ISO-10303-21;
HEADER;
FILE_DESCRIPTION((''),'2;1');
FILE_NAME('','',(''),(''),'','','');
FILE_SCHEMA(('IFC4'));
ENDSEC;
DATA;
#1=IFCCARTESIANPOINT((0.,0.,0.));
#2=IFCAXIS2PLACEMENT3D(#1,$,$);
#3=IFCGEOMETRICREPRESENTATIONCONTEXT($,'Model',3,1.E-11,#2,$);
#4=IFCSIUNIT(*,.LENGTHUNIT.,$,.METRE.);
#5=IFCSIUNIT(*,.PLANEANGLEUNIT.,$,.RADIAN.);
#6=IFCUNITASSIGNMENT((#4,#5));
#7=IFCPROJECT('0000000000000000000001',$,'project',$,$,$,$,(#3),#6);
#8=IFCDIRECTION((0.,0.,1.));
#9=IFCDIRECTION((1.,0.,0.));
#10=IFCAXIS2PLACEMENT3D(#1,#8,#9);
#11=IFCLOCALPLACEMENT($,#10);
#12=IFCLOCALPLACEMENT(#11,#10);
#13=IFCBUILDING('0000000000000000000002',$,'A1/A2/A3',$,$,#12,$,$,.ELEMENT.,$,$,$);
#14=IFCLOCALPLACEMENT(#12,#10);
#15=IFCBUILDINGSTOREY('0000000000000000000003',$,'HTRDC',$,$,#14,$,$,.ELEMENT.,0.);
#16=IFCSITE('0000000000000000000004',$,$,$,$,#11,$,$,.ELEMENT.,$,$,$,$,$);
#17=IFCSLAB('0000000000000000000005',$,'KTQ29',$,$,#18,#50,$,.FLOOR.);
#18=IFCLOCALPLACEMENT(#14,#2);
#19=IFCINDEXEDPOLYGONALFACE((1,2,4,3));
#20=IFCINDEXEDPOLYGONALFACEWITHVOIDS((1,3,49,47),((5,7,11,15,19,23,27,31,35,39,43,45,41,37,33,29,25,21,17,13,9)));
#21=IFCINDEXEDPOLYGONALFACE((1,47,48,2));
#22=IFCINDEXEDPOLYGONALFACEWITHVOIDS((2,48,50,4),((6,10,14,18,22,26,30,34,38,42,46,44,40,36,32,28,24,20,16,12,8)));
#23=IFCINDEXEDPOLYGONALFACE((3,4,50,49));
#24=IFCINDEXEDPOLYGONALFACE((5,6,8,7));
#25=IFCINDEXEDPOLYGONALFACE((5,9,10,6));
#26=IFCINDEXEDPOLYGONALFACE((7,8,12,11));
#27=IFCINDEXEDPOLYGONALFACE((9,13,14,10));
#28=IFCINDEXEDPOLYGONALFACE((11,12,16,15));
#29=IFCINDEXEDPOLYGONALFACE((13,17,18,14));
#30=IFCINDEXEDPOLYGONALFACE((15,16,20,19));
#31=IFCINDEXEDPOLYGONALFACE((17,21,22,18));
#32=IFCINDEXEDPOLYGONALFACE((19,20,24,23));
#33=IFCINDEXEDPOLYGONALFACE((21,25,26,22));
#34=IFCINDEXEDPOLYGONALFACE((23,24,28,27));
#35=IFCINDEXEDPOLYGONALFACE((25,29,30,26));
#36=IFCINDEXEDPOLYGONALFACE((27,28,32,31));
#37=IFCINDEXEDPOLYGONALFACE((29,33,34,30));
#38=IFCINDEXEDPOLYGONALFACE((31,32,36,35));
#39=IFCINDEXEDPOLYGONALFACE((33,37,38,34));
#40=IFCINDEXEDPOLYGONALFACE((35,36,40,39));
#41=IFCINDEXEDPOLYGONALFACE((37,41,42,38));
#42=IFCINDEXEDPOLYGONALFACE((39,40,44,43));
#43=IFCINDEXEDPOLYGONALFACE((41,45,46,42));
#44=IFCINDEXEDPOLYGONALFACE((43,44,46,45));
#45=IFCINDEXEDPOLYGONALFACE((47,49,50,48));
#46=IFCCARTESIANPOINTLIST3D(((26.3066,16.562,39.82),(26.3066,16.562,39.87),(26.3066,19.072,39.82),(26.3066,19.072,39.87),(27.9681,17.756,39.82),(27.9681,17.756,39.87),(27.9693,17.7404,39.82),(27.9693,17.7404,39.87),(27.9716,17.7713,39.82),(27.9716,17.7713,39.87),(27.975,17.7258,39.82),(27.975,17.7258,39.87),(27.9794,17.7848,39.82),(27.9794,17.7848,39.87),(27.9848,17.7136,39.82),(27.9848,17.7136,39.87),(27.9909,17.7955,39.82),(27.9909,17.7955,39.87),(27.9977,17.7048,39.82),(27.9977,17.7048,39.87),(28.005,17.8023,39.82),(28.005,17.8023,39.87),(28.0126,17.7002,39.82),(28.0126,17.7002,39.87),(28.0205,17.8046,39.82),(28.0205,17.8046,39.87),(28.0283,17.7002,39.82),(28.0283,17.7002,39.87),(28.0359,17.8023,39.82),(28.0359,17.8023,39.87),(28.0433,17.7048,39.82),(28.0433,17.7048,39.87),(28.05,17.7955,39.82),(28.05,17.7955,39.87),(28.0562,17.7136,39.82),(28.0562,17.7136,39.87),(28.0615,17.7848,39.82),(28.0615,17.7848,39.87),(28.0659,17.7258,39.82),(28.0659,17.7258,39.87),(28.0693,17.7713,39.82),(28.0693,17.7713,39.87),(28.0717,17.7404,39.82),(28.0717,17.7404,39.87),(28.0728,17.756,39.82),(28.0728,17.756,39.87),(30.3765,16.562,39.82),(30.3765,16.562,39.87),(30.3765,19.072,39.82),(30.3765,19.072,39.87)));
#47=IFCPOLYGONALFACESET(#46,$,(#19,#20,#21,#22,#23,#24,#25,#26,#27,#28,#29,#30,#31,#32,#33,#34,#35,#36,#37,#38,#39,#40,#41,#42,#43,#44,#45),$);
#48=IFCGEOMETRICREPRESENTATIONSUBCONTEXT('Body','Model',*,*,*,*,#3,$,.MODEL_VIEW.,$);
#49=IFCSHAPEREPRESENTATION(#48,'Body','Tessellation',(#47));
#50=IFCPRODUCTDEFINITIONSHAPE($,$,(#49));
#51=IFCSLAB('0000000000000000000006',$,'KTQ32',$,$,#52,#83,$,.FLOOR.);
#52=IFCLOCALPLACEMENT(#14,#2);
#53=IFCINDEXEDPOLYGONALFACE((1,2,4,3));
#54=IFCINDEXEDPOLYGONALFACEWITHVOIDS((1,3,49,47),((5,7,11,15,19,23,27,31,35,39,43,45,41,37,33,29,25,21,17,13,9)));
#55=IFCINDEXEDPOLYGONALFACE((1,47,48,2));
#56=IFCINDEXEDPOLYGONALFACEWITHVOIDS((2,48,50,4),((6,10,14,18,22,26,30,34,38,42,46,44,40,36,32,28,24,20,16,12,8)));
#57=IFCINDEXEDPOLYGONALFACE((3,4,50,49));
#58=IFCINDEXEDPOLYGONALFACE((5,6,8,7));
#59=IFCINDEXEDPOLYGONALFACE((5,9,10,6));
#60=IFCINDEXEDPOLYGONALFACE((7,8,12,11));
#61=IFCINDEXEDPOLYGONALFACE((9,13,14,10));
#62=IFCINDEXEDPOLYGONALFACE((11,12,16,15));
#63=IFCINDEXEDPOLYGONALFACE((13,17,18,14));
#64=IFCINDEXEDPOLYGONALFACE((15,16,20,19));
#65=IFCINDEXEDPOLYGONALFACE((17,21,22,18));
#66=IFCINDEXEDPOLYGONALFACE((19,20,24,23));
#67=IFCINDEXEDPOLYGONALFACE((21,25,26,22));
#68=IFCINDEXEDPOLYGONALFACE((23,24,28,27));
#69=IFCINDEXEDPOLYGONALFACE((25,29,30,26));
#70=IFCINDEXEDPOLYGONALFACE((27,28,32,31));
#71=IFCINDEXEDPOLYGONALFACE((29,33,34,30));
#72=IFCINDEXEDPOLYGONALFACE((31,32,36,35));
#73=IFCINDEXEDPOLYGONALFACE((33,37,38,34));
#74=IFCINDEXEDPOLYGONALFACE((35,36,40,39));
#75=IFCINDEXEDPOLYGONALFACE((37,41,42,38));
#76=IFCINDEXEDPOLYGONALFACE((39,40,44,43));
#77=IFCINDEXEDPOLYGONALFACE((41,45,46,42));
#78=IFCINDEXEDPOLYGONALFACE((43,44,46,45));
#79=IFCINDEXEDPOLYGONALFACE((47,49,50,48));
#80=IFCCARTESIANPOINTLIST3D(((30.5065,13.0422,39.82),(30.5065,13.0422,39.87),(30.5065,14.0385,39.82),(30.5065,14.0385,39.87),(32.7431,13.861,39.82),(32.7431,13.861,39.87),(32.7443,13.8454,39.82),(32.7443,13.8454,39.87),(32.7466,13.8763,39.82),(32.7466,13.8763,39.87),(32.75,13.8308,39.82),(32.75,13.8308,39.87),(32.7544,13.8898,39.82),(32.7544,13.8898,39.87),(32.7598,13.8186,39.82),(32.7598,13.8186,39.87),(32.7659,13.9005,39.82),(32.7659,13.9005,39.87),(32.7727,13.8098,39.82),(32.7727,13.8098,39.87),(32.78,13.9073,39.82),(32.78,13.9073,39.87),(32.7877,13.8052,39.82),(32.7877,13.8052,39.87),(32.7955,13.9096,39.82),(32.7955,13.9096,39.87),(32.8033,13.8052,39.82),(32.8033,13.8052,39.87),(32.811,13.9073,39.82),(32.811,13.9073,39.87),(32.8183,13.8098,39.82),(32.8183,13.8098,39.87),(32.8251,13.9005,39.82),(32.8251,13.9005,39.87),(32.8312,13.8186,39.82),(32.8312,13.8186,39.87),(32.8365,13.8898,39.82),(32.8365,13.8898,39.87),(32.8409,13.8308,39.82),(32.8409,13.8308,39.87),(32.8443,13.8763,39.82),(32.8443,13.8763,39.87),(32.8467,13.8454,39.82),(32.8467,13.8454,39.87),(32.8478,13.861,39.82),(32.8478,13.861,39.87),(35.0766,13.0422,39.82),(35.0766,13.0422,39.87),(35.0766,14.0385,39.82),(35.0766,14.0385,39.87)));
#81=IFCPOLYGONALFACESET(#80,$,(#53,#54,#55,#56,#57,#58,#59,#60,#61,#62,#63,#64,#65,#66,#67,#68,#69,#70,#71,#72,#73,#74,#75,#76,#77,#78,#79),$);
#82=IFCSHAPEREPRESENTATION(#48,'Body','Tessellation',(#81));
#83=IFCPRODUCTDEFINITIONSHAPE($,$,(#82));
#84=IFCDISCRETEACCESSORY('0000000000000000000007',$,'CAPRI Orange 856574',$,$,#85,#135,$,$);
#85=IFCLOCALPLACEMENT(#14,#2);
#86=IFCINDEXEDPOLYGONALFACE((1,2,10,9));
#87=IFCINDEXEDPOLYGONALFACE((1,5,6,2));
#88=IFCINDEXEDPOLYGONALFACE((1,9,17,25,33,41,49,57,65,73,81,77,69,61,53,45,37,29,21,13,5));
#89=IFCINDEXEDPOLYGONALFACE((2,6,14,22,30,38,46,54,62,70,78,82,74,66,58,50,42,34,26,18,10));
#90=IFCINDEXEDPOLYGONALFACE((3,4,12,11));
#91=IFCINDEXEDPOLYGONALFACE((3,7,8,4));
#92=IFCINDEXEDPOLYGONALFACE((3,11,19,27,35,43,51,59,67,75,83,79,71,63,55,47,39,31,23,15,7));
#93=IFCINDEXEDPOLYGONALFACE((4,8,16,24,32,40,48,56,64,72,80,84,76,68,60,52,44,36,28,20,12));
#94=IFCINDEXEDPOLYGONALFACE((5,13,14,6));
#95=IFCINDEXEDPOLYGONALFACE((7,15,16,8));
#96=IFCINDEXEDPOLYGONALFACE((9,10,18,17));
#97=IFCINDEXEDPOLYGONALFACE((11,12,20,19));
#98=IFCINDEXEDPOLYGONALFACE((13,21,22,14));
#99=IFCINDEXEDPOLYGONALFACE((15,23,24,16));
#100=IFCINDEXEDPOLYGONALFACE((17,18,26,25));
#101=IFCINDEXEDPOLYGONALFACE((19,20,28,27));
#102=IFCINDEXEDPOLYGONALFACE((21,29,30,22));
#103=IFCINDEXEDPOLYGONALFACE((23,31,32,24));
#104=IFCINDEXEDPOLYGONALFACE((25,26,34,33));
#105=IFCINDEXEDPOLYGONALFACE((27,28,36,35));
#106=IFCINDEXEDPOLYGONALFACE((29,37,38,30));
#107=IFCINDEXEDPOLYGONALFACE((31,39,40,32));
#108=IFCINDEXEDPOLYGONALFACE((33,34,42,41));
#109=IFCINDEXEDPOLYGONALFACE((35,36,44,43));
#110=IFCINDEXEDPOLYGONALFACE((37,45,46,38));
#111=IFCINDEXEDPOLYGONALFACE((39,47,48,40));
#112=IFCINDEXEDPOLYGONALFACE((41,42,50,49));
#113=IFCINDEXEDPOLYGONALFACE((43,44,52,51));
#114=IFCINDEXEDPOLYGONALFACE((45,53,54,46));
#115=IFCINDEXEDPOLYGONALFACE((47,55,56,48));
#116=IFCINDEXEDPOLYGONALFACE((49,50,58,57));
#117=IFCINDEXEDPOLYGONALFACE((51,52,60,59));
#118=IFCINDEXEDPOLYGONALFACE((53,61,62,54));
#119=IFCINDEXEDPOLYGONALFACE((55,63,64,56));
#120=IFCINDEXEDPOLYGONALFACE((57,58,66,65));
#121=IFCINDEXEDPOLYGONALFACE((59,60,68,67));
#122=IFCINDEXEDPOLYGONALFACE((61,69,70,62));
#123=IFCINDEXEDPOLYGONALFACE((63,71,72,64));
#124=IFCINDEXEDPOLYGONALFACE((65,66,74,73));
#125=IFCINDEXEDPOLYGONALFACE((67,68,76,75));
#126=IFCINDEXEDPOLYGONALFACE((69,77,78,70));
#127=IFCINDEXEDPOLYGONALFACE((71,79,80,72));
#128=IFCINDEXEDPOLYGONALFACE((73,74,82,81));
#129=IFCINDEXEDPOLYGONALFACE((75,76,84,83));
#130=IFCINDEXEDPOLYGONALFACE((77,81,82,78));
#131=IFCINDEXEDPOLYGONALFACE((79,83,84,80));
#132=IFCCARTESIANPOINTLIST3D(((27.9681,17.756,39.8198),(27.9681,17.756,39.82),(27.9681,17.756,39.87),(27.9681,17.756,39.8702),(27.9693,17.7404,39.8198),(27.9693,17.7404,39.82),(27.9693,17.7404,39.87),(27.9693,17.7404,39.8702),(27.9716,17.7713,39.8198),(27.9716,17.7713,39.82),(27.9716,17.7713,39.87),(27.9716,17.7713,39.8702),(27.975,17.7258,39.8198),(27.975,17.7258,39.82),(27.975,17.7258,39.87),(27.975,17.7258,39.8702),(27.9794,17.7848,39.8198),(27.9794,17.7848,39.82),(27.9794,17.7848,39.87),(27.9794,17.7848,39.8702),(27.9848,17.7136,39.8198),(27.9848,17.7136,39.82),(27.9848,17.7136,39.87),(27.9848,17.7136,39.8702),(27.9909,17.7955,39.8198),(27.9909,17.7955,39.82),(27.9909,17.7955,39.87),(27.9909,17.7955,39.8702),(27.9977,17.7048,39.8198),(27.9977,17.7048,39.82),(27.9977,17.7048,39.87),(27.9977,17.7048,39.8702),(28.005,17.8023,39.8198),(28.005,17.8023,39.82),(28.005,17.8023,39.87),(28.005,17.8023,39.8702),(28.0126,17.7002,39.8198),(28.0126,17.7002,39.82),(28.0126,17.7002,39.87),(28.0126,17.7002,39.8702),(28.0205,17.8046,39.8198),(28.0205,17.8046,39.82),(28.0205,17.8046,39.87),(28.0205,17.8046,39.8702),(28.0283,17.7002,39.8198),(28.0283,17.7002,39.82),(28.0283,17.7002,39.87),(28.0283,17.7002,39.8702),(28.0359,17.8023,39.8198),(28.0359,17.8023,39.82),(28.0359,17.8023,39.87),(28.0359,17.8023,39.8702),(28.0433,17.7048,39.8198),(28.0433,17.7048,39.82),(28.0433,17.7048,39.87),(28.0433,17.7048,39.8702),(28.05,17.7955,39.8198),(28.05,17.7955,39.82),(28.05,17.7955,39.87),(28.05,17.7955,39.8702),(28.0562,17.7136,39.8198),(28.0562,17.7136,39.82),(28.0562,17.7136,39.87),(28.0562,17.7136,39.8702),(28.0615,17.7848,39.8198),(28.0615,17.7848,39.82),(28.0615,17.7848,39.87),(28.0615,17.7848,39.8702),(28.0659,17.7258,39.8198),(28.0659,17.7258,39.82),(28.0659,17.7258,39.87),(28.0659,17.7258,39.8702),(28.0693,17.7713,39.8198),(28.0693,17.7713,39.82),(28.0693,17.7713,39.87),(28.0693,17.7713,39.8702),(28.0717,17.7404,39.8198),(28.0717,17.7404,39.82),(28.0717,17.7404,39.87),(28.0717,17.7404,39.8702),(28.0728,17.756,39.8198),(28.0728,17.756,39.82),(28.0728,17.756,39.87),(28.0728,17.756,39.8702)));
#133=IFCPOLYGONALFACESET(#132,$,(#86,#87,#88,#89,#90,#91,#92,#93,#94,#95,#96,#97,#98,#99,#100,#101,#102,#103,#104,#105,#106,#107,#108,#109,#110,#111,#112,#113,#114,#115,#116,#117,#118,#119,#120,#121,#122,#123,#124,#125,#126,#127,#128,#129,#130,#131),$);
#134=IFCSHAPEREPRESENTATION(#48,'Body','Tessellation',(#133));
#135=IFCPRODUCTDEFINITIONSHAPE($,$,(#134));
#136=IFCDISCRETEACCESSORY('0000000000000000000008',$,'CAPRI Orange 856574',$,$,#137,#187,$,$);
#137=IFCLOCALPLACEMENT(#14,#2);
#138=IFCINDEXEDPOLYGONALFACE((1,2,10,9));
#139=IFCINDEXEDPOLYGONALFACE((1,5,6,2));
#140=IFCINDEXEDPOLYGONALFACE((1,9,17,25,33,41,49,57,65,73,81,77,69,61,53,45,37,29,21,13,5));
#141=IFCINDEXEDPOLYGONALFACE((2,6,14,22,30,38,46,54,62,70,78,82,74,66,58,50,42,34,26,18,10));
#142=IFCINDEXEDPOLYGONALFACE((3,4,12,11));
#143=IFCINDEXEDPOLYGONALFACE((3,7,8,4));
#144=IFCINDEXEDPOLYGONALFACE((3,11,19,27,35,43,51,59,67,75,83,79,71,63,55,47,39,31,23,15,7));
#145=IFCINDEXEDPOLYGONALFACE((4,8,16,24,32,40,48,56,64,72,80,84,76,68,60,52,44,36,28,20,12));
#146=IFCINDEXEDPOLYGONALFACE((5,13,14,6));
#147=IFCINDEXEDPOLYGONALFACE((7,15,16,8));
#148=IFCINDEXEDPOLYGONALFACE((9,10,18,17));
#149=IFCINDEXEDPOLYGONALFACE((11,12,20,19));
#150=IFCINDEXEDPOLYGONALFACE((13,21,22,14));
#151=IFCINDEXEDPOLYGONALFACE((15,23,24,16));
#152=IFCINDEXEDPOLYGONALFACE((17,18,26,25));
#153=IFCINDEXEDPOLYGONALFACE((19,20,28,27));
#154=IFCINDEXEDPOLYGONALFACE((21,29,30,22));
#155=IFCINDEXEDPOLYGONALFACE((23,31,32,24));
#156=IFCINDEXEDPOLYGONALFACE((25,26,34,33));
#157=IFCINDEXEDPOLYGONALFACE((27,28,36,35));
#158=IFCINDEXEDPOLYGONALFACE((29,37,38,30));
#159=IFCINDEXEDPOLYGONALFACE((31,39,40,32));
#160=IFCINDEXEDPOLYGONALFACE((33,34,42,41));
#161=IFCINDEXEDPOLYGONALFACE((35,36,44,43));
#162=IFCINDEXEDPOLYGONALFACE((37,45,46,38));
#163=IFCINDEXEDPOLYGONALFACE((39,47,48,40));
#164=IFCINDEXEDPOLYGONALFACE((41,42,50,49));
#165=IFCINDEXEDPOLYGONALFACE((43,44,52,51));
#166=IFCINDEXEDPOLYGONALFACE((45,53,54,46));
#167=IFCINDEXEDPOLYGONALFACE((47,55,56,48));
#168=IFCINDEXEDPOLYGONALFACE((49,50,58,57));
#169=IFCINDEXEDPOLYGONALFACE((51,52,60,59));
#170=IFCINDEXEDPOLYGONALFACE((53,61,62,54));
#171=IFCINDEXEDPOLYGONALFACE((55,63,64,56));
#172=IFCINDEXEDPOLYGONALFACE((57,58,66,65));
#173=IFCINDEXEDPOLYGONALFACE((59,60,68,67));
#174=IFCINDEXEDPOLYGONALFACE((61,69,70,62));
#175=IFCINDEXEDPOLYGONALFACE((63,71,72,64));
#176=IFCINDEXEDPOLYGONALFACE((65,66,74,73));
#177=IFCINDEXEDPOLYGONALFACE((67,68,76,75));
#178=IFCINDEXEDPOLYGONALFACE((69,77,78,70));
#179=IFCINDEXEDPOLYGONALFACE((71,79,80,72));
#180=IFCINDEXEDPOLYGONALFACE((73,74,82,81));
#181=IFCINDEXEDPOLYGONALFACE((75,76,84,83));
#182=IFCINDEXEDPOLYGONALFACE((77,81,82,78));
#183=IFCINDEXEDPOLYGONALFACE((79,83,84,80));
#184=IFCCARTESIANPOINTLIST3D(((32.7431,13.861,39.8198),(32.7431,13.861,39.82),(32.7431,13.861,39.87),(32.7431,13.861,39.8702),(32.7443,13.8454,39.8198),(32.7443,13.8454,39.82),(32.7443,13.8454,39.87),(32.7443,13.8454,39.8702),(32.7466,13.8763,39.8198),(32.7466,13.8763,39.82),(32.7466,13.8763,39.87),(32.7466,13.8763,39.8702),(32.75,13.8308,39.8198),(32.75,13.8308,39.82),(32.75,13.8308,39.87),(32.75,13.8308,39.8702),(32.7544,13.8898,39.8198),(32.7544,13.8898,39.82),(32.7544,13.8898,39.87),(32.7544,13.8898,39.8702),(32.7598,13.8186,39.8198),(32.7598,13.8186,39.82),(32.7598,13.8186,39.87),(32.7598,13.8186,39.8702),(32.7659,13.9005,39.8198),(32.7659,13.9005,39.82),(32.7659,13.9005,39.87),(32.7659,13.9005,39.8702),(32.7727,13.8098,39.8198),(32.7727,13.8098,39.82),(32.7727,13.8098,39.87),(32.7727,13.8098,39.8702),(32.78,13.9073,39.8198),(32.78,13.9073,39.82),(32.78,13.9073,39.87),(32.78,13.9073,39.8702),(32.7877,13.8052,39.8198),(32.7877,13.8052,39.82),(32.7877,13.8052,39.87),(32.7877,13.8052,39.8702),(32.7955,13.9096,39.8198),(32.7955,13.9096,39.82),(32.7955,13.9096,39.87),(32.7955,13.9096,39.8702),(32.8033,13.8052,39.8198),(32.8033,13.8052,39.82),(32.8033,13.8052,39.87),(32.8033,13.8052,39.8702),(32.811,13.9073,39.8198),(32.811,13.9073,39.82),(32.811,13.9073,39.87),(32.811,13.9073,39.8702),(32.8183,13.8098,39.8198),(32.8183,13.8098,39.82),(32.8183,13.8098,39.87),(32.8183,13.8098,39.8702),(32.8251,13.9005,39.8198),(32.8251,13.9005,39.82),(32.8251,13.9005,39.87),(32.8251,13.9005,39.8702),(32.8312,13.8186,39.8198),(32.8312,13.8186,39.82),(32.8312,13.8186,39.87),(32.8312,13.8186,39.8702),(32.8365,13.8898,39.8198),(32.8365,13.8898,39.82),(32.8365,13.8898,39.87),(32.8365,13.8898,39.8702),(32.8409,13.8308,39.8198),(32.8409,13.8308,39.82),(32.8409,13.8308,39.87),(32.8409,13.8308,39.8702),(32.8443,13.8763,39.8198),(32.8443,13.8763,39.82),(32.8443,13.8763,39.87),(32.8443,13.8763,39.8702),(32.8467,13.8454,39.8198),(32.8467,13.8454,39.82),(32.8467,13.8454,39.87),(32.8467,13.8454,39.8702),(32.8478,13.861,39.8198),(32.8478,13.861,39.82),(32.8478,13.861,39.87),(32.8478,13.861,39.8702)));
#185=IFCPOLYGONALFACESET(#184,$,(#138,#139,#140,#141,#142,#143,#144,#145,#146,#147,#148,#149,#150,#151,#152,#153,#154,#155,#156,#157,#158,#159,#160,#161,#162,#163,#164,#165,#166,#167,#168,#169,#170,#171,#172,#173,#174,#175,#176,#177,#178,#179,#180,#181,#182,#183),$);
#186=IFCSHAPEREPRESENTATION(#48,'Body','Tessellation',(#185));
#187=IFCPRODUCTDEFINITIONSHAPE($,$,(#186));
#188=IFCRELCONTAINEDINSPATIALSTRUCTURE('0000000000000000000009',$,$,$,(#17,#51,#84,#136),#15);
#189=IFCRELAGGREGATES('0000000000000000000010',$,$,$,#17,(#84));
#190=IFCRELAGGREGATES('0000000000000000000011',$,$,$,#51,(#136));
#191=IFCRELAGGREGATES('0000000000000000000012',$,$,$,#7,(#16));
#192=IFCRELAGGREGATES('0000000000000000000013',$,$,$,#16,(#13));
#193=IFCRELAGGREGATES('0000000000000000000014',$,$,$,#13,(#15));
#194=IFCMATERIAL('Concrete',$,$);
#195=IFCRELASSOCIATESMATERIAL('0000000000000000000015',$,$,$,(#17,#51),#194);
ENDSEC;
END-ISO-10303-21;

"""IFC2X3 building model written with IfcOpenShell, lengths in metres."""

from ifc_helpers import new_model, si_unit, frame, frame_2d, origin, origin_with_axes, origin_2d_with_axis, place, context, subcontext, project, spatial, polyline, circle, outline, extrude, material, element, aggregate, save


model = new_model("IFC2X3")

# Units and contexts
model_context = context("Model", 3, precision=1e-11, world=origin())
body_context = subcontext(model_context, "Body", "Model", "MODEL_VIEW")
ifc_project = project(units=[si_unit("LENGTHUNIT", "METRE"), si_unit("PLANEANGLEUNIT", "RADIAN")], contexts=[model_context])

# Site, building, storey
site_placement = place(None, origin_with_axes())
site = spatial("IfcSite", under=ifc_project, at=site_placement, CompositionType="ELEMENT")
building_placement = place(site_placement, origin_with_axes())
building = spatial("IfcBuilding", under=site, at=building_placement, Name="A1/A2/A3", CompositionType="ELEMENT")
storey_placement = place(building_placement, origin_with_axes())
storey = spatial("IfcBuildingStorey", under=building, at=storey_placement, Name="HTRDC", CompositionType="ELEMENT", Elevation=0.0)

# Slabs, openings
ifc_material = material(Name="Concrete")
slab_1_placement = place(storey_placement, frame((26.3066, 16.562, 39.82), z_axis=(0.0, 0.0, 1.0), x_axis=(1.0, 0.0, 0.0)))
slab_1 = element("IfcSlab", 1, at=slab_1_placement, inside=storey, material=ifc_material, Name="KTQ29", PredefinedType="FLOOR", context=body_context, shape_type="SweptSolid", body=[
    extrude(outline(polyline([(0.0, 0.0), (0.0, -4.0699), (2.51, -4.0699), (2.51, 0.0), (0.0, 0.0)])), frame((0.0, 0.0, 0.0), z_axis=(0.0, 0.0, 1.0), x_axis=(0.0, 1.0, 0.0)), (0.0, 0.0, 1.0), 0.05),
])
opening_1_placement = place(slab_1_placement, frame((1.7139, 1.1901, 0.0), z_axis=(0.0, 0.0, 1.0), x_axis=(1.0, 0.0, 0.0)))
element("IfcOpeningElement", 2, at=opening_1_placement, cuts=slab_1, ObjectType="Opening", context=body_context, shape_type="SweptSolid", body=[
    extrude(circle(Radius=0.0525, at=origin_2d_with_axis()), frame((0.0, 0.0, 0.0), z_axis=(0.0, 0.0, 1.0), x_axis=(0.0, 1.0, 0.0)), (0.0, 0.0, 1.0), 0.05),
])
slab_2_placement = place(storey_placement, frame((30.5065, 13.0422, 39.82), z_axis=(0.0, 0.0, 1.0), x_axis=(1.0, 0.0, 0.0)))
slab_2 = element("IfcSlab", 3, at=slab_2_placement, inside=storey, material=ifc_material, Name="KTQ32", PredefinedType="FLOOR", context=body_context, shape_type="SweptSolid", body=[
    extrude(outline(polyline([(0.0, 0.0), (0.0, -4.57), (0.9963, -4.57), (0.9963, 0.0), (0.0, 0.0)])), frame((0.0, 0.0, 0.0), z_axis=(0.0, 0.0, 1.0), x_axis=(0.0, 1.0, 0.0)), (0.0, 0.0, 1.0), 0.05),
])
opening_2_placement = place(slab_2_placement, frame((2.2889, 0.8149, 0.0), z_axis=(0.0, 0.0, 1.0), x_axis=(1.0, 0.0, 0.0)))
element("IfcOpeningElement", 4, at=opening_2_placement, cuts=slab_2, ObjectType="Opening", context=body_context, shape_type="SweptSolid", body=[
    extrude(circle(Radius=0.0525, at=origin_2d_with_axis()), frame((0.0, 0.0, 0.0), z_axis=(0.0, 0.0, 1.0), x_axis=(0.0, 1.0, 0.0)), (0.0, 0.0, 1.0), 0.05),
])

# Discrete accessories
discrete_accessory_1_placement = place(storey_placement, frame((26.3066, 16.562, 39.8199), z_axis=(0.0, 0.0, 1.0), x_axis=(1.0, 0.0, 0.0)))
discrete_accessory_1 = element("IfcDiscreteAccessory", 5, at=discrete_accessory_1_placement, inside=storey, Name="CAPRI Orange 856574", context=body_context, shape_type="SweptSolid", body=[
    extrude(circle(Radius=0.0525, at=frame_2d((1.1901, -1.7139), x_axis=(1.0, 0.0))), frame((0.0, 0.0, 0.0), z_axis=(0.0, 0.0, 1.0), x_axis=(0.0, 1.0, 0.0)), (0.0, 0.0, 1.0), 0.0503),
])
aggregate(slab_1, [discrete_accessory_1])
discrete_accessory_2_placement = place(storey_placement, frame((30.5065, 13.0422, 39.8199), z_axis=(0.0, 0.0, 1.0), x_axis=(1.0, 0.0, 0.0)))
discrete_accessory_2 = element("IfcDiscreteAccessory", 6, at=discrete_accessory_2_placement, inside=storey, Name="CAPRI Orange 856574", context=body_context, shape_type="SweptSolid", body=[
    extrude(circle(Radius=0.0525, at=frame_2d((0.8149, -2.2889), x_axis=(1.0, 0.0))), frame((0.0, 0.0, 0.0), z_axis=(0.0, 0.0, 1.0), x_axis=(0.0, 1.0, 0.0)), (0.0, 0.0, 1.0), 0.0503),
])
aggregate(slab_2, [discrete_accessory_2])

save(model, "model.ifc")
